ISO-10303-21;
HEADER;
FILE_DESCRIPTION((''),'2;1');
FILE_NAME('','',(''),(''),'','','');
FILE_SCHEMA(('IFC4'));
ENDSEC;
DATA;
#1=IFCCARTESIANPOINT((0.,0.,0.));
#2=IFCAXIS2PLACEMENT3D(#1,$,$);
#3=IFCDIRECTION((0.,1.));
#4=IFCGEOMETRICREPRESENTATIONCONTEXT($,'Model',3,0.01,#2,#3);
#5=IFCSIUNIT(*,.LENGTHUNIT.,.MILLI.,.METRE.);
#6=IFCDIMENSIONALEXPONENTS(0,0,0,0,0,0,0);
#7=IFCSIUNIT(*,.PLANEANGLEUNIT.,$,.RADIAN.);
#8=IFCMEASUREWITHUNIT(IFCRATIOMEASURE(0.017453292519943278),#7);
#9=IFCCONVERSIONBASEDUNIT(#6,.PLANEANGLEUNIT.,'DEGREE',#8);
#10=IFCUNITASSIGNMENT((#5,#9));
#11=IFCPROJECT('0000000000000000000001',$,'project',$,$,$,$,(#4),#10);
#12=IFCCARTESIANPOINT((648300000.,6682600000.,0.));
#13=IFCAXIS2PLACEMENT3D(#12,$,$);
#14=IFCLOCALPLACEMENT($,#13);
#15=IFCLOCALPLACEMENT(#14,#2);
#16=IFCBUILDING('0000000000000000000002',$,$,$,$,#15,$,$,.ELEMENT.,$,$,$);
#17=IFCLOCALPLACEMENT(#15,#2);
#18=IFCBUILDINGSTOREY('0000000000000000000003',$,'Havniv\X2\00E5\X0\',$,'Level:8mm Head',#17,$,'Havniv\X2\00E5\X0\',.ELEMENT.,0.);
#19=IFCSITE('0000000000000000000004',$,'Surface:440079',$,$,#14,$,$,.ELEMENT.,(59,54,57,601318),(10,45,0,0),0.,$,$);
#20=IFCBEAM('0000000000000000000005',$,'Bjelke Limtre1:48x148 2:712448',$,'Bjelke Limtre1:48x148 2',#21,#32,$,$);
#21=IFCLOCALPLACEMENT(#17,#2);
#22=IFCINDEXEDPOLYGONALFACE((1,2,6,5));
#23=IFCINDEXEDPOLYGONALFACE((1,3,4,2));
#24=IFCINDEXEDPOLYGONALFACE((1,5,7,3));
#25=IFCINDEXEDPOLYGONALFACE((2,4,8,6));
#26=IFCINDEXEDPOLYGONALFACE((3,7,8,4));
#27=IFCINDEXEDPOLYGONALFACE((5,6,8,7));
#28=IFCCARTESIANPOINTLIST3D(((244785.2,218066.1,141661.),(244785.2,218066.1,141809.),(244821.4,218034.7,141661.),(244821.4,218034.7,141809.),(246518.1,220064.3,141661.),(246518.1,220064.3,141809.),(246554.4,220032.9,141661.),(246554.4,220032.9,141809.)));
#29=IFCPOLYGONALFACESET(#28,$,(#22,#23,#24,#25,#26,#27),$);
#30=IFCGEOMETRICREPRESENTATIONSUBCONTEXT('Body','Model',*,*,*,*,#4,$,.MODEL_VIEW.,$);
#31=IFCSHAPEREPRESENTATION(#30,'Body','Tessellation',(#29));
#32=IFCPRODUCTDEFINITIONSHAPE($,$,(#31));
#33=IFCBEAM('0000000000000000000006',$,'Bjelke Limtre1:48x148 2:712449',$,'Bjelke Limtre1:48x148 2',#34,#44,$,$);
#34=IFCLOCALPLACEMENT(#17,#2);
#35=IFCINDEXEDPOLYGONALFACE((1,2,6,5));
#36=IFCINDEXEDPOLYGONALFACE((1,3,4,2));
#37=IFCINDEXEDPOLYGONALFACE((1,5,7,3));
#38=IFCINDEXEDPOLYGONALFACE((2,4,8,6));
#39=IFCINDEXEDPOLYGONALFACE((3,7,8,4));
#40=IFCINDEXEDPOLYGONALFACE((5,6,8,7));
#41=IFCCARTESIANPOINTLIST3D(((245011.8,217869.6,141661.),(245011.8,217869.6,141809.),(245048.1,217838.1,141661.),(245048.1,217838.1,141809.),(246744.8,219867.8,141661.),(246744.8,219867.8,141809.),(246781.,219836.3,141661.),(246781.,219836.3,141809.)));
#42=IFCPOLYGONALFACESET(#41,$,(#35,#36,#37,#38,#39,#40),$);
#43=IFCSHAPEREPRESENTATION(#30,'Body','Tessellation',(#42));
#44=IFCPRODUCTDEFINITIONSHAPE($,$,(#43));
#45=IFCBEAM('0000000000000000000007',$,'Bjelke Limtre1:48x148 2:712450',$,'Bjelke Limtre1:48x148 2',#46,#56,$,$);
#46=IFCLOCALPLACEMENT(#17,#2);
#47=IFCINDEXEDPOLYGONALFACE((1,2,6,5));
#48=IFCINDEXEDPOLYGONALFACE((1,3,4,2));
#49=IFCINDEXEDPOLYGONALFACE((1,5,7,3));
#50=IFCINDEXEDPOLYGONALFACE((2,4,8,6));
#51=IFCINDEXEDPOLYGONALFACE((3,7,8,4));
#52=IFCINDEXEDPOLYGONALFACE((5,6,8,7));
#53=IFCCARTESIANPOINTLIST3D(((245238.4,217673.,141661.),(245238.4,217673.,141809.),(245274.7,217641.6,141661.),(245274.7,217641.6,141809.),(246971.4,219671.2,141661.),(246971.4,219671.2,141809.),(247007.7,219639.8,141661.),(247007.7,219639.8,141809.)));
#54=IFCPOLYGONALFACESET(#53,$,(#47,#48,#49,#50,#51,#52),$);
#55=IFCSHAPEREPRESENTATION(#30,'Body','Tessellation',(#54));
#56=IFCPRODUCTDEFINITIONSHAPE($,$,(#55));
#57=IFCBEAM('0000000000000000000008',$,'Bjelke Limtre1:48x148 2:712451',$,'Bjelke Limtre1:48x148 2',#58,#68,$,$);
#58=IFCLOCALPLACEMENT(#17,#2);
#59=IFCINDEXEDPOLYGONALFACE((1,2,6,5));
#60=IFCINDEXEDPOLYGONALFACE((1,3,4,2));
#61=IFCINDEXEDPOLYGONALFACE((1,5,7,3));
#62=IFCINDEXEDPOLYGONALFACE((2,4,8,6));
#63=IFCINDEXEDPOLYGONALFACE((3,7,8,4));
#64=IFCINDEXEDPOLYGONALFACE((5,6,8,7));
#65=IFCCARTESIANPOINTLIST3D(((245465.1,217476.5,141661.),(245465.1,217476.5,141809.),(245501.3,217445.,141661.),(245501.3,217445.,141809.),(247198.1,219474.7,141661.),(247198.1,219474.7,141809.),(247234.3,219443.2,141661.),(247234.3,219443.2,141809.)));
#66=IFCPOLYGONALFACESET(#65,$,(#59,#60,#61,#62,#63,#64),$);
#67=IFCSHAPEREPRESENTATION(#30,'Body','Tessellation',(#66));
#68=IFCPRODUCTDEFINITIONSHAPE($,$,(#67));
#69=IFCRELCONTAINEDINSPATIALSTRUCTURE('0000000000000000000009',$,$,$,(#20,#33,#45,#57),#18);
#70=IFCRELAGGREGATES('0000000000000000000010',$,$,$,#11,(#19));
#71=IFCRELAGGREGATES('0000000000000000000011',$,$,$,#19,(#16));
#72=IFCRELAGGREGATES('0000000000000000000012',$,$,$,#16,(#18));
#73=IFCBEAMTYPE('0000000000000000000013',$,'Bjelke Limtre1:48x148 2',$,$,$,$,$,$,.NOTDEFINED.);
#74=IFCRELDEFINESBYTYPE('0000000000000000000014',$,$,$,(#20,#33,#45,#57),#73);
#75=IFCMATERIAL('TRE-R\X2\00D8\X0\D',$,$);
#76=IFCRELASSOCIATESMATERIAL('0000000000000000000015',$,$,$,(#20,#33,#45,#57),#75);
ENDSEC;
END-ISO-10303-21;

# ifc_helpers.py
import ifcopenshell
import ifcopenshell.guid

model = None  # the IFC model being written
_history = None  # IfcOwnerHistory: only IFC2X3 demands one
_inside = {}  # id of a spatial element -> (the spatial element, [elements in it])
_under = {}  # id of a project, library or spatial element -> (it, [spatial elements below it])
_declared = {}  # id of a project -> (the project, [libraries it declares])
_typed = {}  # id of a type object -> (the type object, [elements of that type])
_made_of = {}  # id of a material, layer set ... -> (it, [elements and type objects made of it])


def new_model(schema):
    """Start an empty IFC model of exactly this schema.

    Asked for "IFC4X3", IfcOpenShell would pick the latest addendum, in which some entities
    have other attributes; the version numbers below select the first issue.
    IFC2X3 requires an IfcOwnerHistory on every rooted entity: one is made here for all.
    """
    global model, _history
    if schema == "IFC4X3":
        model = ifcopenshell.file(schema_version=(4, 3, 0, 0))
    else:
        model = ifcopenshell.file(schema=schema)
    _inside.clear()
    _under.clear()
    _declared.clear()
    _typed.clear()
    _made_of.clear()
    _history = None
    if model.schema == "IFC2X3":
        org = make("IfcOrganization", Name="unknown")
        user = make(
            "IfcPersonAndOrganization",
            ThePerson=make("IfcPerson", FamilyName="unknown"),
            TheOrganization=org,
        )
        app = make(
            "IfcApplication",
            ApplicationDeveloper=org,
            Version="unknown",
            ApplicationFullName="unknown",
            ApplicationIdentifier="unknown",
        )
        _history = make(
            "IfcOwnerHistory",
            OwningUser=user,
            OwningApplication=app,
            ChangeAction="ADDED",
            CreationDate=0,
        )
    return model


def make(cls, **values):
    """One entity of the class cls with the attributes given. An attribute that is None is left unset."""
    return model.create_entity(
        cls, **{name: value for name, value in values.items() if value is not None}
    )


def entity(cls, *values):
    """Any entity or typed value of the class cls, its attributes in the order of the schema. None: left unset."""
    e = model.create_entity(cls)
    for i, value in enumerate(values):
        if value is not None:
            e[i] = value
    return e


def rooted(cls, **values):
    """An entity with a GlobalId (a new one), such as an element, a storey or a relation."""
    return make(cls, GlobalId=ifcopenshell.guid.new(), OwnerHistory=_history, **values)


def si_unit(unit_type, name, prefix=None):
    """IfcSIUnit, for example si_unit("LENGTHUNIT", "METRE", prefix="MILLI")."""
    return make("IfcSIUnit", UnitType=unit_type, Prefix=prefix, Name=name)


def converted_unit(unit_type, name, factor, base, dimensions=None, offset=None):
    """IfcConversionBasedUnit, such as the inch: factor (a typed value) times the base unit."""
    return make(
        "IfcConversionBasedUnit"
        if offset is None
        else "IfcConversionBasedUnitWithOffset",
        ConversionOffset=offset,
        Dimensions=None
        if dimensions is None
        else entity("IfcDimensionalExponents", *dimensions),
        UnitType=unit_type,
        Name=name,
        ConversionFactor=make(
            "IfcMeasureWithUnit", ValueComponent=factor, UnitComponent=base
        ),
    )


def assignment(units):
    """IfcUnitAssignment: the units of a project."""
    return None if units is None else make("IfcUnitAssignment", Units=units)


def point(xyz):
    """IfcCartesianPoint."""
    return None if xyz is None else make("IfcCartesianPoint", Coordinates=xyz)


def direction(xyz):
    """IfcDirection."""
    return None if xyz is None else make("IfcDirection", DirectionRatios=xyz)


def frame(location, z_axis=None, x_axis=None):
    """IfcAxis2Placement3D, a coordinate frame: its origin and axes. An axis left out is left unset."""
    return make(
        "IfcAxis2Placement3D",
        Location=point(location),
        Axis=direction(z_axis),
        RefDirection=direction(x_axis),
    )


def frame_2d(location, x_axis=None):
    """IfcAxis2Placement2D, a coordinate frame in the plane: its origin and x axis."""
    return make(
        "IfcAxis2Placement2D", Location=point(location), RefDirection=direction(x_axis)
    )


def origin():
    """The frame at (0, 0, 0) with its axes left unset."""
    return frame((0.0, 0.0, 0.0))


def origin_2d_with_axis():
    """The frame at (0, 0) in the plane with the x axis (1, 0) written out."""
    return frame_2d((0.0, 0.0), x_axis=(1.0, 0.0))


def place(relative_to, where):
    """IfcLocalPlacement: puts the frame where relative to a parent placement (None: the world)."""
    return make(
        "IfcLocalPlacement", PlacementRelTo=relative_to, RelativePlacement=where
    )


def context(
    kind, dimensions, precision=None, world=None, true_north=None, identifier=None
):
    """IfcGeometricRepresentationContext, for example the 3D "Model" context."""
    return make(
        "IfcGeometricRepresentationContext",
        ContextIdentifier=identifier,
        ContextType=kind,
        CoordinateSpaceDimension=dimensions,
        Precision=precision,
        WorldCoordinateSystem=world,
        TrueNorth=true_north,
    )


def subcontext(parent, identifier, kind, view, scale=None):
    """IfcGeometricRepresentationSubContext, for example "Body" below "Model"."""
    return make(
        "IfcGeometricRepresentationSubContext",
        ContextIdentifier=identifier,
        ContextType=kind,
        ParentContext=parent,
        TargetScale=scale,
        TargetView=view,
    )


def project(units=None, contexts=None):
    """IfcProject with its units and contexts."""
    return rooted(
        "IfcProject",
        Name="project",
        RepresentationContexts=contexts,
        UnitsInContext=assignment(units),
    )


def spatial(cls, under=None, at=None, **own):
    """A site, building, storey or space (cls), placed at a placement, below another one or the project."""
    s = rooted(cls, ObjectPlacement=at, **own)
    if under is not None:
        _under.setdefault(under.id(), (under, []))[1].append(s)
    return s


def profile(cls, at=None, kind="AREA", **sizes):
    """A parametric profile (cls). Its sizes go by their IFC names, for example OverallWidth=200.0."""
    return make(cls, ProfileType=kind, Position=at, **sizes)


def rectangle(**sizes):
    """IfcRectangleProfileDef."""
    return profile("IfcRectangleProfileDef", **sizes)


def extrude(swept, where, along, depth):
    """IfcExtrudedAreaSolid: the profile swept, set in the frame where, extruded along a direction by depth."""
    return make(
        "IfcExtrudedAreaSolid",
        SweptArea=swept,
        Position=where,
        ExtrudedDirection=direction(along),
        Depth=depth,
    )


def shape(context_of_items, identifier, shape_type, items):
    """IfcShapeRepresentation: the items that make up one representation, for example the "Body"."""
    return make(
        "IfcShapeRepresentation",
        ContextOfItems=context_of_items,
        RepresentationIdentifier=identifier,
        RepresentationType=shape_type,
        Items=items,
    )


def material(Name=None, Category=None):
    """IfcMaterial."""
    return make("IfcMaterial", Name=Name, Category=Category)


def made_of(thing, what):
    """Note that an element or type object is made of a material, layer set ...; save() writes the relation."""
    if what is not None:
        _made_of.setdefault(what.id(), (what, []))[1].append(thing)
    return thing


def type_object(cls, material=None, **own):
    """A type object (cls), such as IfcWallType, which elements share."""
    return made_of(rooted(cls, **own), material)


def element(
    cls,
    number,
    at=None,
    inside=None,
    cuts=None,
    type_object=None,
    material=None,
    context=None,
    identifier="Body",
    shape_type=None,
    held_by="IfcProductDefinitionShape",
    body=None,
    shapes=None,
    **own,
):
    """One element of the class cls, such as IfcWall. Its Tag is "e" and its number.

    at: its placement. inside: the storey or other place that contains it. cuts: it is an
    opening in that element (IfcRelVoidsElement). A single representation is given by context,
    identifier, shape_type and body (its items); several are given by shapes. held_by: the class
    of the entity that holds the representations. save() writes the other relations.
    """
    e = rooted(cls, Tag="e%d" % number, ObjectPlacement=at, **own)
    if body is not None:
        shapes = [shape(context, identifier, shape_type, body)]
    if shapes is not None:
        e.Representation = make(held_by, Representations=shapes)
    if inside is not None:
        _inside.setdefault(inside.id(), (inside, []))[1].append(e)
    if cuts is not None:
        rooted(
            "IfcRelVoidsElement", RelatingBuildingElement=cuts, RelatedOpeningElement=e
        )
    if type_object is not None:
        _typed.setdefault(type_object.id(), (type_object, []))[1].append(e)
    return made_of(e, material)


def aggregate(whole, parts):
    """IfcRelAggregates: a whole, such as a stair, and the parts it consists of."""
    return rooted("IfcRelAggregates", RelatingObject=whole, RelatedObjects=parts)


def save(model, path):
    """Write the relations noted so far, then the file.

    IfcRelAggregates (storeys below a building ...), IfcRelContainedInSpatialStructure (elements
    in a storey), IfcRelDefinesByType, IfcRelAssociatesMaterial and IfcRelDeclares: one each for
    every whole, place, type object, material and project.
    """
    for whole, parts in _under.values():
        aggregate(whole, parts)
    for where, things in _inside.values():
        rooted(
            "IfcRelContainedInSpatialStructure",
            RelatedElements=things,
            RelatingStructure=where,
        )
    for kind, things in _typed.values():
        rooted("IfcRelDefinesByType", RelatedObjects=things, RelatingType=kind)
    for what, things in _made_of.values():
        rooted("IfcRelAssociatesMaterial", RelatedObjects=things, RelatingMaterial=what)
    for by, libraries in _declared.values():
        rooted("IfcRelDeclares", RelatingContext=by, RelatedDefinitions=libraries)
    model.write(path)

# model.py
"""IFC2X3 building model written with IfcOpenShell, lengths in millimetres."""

from ifc_helpers import new_model, entity, si_unit, converted_unit, direction, frame, frame_2d, origin, origin_2d_with_axis, place, context, subcontext, project, spatial, rectangle, extrude, material, type_object, element, save


model = new_model("IFC2X3")

# Units and contexts
model_context = context("Model", 3, precision=0.01, world=origin(), true_north=direction((0.0, 1.0)))
body_context = subcontext(model_context, "Body", "Model", "MODEL_VIEW")
ifc_project = project(units=[si_unit("LENGTHUNIT", "METRE", prefix="MILLI"), converted_unit("PLANEANGLEUNIT", "DEGREE", entity("IfcRatioMeasure", 0.017453292519943278), si_unit("PLANEANGLEUNIT", "RADIAN"), dimensions=[0, 0, 0, 0, 0, 0, 0])], contexts=[model_context])

# Site, building, storey
site_placement = place(None, frame((648300000.0, 6682600000.0, 0.0)))
site = spatial("IfcSite", under=ifc_project, at=site_placement, Name="Surface:440079", CompositionType="ELEMENT", RefLatitude=(59, 54, 57, 601318), RefLongitude=(10, 45, 0, 0), RefElevation=0.0)
building_placement = place(site_placement, origin())
building = spatial("IfcBuilding", under=site, at=building_placement, CompositionType="ELEMENT")
storey_placement = place(building_placement, origin())
storey = spatial("IfcBuildingStorey", under=building, at=storey_placement, Name="Havnivå", ObjectType="Level:8mm Head", LongName="Havnivå", CompositionType="ELEMENT", Elevation=0.0)

# Beams
ifc_material = material(Name="TRE-RØD")
beam_type = type_object("IfcBeamType", Name="Bjelke Limtre1:48x148 2", PredefinedType="NOTDEFINED")
beam_1_placement = place(storey_placement, frame((246536.3, 220048.6, 141809.0), z_axis=(0.0, 0.0, 1.0), x_axis=(-0.655187, -0.755467, 0.0)))
element("IfcBeam", 1, at=beam_1_placement, inside=storey, type_object=beam_type, material=ifc_material, Name="Bjelke Limtre1:48x148 2:712448", ObjectType="Bjelke Limtre1:48x148 2", context=body_context, shape_type="SweptSolid", body=[
    extrude(rectangle(XDim=148.0, YDim=48.0, at=frame_2d((0.0, 0.0), x_axis=(1.0, 0.0))), frame((0.0, 0.0, -74.0), z_axis=(1.0, 0.0, 0.0), x_axis=(0.0, 0.0, -1.0)), (0.0, 0.0, 1.0), 2645.0),
])
for number, where, z_axis, x_axis, name in (
    (2, (246762.9, 219852.0, 141809.0), (0.0, 0.0, 1.0), (-0.655187, -0.755467, 0.0), "Bjelke Limtre1:48x148 2:712449"),
    (3, (246989.5, 219655.5, 141809.0), (0.0, 0.0, 1.0), (-0.655187, -0.755467, 0.0), "Bjelke Limtre1:48x148 2:712450"),
    (4, (247216.2, 219458.9, 141809.0), (0.0, 0.0, 1.0), (-0.655187, -0.755467, 0.0), "Bjelke Limtre1:48x148 2:712451"),
):
    element("IfcBeam", number, at=place(storey_placement, frame(where, z_axis=z_axis, x_axis=x_axis)), inside=storey, type_object=beam_type, material=ifc_material, Name=name, ObjectType="Bjelke Limtre1:48x148 2", context=body_context, shape_type="SweptSolid", body=[
        extrude(rectangle(XDim=148.0, YDim=48.0, at=origin_2d_with_axis()), frame((0.0, 0.0, -74.0), z_axis=(1.0, 0.0, 0.0), x_axis=(0.0, 0.0, -1.0)), (0.0, 0.0, 1.0), 2645.0),
    ])

save(model, "model.ifc")
